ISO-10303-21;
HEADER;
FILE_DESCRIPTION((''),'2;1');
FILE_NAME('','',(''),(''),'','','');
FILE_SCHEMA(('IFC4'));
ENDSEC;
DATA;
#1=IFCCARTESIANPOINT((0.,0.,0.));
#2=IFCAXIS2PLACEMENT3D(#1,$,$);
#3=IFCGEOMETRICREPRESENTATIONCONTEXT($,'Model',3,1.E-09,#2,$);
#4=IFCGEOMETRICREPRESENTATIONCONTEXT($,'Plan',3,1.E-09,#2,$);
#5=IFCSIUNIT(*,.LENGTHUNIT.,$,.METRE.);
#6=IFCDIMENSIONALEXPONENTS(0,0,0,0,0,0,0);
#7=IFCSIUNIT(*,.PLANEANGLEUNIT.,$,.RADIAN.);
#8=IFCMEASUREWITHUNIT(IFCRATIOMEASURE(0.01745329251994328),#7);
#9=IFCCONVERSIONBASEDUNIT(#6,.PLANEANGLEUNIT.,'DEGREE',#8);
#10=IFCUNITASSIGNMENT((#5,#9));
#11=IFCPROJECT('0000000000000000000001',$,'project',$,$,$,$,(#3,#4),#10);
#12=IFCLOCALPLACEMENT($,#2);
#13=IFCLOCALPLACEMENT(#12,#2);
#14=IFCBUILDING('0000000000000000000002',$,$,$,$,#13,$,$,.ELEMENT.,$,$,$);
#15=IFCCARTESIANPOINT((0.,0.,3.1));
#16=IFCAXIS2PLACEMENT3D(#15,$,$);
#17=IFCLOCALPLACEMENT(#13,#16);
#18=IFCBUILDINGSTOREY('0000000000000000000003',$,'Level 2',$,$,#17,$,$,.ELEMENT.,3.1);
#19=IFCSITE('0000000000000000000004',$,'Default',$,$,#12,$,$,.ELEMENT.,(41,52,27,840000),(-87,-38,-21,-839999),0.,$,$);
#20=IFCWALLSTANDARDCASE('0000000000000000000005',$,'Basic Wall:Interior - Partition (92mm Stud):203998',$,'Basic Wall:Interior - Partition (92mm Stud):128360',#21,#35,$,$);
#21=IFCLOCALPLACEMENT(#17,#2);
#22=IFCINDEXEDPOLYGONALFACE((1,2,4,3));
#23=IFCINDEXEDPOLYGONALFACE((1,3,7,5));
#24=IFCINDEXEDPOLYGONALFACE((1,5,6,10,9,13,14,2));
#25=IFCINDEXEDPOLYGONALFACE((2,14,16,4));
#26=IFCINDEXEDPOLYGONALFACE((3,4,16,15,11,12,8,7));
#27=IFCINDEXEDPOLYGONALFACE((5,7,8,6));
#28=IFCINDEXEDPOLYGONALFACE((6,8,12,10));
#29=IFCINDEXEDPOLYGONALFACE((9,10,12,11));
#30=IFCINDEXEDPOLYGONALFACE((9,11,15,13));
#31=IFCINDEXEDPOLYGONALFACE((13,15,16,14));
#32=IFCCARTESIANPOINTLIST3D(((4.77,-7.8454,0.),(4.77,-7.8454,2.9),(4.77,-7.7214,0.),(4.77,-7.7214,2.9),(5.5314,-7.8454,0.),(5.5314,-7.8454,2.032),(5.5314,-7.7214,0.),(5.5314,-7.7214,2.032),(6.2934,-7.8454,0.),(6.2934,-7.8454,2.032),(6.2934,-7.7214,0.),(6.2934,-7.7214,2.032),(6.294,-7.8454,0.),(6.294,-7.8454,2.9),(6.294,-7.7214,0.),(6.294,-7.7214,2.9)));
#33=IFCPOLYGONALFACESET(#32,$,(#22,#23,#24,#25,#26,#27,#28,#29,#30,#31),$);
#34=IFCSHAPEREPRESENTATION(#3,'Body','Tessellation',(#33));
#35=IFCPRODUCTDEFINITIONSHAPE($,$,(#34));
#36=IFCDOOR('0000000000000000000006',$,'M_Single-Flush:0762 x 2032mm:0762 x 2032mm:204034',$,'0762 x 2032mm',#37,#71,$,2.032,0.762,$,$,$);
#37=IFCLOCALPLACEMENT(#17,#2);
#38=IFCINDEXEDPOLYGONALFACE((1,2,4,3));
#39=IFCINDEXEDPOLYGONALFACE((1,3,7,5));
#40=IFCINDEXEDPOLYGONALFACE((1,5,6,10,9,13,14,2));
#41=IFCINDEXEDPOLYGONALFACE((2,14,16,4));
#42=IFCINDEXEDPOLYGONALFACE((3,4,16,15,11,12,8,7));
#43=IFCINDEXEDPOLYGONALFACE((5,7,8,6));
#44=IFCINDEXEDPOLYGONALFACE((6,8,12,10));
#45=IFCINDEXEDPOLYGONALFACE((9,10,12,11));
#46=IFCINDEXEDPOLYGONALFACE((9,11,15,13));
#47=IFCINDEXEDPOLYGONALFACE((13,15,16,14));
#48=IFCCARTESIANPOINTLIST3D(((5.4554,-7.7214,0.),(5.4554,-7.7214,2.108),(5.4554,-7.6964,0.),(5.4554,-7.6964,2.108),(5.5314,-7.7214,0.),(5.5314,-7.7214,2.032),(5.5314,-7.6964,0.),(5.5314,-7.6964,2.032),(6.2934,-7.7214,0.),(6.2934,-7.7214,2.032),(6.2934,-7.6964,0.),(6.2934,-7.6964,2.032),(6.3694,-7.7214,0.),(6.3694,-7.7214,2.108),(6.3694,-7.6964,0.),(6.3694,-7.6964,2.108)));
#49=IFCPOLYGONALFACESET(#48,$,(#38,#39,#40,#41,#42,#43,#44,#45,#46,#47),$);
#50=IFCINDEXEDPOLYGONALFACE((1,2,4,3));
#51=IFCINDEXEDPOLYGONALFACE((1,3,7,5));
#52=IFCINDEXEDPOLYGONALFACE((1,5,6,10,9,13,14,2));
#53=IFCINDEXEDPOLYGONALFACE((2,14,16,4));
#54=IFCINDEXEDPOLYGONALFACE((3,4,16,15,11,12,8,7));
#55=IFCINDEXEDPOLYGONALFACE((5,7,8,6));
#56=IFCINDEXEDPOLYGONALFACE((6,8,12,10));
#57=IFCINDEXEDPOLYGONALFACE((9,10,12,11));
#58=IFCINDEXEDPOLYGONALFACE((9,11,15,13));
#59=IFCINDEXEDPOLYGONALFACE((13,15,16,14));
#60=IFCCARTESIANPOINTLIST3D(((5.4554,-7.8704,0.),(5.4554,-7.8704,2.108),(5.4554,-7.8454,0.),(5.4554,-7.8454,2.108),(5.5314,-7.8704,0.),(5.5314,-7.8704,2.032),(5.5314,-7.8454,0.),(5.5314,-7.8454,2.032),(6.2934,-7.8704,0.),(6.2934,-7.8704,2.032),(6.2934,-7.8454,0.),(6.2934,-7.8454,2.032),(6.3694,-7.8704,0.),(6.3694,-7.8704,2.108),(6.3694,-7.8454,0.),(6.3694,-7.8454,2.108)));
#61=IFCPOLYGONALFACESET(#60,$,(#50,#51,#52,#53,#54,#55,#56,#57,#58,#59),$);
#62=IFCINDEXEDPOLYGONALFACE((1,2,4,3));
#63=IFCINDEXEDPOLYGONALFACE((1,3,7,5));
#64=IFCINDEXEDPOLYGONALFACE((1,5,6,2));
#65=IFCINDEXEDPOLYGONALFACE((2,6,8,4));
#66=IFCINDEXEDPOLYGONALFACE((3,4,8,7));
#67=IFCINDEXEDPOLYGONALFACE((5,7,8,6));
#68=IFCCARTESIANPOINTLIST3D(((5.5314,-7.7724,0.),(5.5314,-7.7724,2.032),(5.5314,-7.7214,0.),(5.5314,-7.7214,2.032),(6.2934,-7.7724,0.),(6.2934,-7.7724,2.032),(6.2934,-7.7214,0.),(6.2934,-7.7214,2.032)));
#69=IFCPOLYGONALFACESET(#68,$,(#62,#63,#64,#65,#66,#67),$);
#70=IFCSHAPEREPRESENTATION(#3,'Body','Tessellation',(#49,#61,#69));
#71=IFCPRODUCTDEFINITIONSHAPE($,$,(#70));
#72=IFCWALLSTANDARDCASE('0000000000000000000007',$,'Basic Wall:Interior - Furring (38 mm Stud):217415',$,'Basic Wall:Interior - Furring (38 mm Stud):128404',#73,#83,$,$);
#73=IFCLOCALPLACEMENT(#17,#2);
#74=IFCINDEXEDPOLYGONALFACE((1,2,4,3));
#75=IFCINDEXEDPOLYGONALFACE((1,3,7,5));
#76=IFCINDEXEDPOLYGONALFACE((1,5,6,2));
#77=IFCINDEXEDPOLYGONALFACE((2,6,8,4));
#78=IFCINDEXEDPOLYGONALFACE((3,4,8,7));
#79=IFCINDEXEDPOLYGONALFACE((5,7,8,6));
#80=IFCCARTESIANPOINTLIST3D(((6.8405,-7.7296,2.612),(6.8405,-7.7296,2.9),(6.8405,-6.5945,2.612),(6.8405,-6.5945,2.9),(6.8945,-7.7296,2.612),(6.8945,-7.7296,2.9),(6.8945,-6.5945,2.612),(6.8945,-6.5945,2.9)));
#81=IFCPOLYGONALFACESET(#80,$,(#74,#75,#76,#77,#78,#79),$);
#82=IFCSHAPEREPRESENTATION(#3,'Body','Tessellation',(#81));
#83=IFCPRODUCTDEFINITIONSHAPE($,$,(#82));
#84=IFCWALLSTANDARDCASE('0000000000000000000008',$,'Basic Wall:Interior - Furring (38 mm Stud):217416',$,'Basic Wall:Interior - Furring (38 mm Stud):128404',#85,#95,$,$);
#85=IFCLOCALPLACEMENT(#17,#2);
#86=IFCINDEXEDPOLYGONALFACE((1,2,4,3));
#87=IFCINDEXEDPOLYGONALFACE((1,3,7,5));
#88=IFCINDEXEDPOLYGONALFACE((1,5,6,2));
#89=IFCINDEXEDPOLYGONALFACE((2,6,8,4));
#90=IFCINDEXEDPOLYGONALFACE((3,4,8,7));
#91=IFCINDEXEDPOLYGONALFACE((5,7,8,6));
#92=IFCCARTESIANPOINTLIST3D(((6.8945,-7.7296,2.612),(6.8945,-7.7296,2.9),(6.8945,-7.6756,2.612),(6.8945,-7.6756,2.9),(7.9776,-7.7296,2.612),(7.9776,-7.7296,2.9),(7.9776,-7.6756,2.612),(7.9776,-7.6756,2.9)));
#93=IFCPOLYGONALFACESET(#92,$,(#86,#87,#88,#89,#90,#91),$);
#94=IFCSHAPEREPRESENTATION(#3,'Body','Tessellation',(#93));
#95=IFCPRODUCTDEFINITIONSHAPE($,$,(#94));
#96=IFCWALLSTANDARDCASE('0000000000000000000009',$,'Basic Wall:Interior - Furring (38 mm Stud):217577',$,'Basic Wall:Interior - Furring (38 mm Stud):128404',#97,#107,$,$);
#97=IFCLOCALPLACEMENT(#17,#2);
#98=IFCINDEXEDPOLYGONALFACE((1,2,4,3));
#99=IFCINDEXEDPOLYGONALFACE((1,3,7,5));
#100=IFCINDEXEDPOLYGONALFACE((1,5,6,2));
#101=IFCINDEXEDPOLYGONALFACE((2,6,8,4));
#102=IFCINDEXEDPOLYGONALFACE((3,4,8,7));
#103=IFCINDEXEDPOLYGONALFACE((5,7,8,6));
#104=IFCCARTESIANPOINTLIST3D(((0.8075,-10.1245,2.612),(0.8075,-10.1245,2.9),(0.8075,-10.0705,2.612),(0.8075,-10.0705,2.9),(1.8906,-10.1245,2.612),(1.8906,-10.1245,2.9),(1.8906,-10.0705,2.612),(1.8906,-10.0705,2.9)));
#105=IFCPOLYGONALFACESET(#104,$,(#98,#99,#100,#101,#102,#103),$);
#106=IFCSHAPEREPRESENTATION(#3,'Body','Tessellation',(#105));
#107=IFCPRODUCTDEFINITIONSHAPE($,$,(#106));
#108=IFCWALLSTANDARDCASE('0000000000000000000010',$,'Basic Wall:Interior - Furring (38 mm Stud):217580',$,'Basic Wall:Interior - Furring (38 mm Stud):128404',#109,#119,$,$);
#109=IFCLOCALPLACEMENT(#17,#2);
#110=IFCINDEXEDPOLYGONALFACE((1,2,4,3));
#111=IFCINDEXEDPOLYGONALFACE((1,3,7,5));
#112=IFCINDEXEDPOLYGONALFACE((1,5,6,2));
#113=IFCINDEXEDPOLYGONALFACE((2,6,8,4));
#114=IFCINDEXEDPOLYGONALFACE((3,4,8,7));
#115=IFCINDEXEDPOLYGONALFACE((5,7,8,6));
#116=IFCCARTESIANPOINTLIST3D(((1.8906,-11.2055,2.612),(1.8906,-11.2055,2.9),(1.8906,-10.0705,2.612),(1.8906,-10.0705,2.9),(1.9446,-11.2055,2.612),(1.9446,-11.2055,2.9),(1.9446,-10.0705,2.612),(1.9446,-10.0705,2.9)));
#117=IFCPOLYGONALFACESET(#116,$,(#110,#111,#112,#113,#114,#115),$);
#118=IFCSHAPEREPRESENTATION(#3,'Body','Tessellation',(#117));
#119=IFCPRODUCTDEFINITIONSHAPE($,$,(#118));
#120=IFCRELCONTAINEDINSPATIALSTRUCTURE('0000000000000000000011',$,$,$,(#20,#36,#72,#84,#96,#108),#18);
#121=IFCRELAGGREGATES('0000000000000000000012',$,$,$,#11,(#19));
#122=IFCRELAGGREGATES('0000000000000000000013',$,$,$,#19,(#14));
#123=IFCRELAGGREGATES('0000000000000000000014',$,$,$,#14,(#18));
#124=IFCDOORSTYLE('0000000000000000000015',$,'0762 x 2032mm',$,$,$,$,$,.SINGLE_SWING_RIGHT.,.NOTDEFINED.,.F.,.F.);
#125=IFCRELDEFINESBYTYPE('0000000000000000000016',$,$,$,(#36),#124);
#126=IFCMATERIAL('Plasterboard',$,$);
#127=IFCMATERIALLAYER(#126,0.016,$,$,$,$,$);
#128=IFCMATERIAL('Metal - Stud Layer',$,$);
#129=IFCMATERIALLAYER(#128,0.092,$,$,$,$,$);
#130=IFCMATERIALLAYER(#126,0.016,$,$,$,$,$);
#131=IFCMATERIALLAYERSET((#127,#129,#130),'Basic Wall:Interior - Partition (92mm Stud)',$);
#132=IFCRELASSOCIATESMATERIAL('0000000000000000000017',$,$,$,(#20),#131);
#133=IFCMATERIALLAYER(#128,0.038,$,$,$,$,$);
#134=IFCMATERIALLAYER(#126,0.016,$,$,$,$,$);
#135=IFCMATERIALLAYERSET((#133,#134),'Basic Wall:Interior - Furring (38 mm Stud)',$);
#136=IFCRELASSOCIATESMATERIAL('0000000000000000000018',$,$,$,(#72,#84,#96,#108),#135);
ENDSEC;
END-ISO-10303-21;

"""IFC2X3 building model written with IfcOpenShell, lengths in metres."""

from ifc_helpers import new_model, entity, si_unit, converted_unit, frame, frame_2d, origin, origin_2d_with_axis, place, context, project, spatial, polyline, rectangle, outline, extrude, source, transform, mapped, material, layer, layer_set, layer_usage, type_object, type_shapes, element, fill, save


model = new_model("IFC2X3")

# Units and contexts
model_context = context("Model", 3, precision=1e-09, world=origin())
plan_context = context("Plan", 3, precision=1e-09, world=origin())
ifc_project = project(units=[si_unit("LENGTHUNIT", "METRE"), converted_unit("PLANEANGLEUNIT", "DEGREE", entity("IfcRatioMeasure", 0.01745329251994328), si_unit("PLANEANGLEUNIT", "RADIAN"), dimensions=[0, 0, 0, 0, 0, 0, 0])], contexts=[model_context, plan_context])

# Site, building, storey
site_placement = place(None, origin())
site = spatial("IfcSite", under=ifc_project, at=site_placement, Name="Default", CompositionType="ELEMENT", RefLatitude=(41, 52, 27, 840000), RefLongitude=(-87, -38, -21, -839999), RefElevation=0.0)
building_placement = place(site_placement, origin())
building = spatial("IfcBuilding", under=site, at=building_placement, CompositionType="ELEMENT")
storey_placement = place(building_placement, frame((0.0, 0.0, 3.1)))
storey = spatial("IfcBuildingStorey", under=building, at=storey_placement, Name="Level 2", CompositionType="ELEMENT", Elevation=3.1)

# Shared definitions
ifc_material_1 = material(Name="Plasterboard")
ifc_material_2 = material(Name="Metal - Stud Layer")
ifc_layer_1 = layer(ifc_material_1, 0.016)
ifc_layer_2 = layer(ifc_material_2, 0.092)
ifc_layer_3 = layer(ifc_material_1, 0.016)
ifc_layer_set_1 = layer_set([ifc_layer_1, ifc_layer_2, ifc_layer_3], Name="Basic Wall:Interior - Partition (92mm Stud)")

# Wall, opening, door
door_style = type_object("IfcDoorStyle", Name="0762 x 2032mm", ConstructionType="NOTDEFINED", OperationType="SINGLE_SWING_RIGHT", ParameterTakesPrecedence=False, Sizeable=False)
shared_shape = source(origin(), model_context, "Body", "SweptSolid", [
    extrude(outline(polyline([(-0.457, -1.073), (0.457, -1.073), (0.457, 1.035), (0.381, 1.035), (0.381, -0.997), (-0.381, -0.997), (-0.381, 1.035), (-0.457, 1.035), (-0.457, -1.073)])), frame((0.381, 0.124, 1.035), z_axis=(0.0, 1.0, 0.0), x_axis=(1.0, 0.0, 0.0)), (0.0, 0.0, 1.0), 0.025),
    extrude(outline(polyline([(-1.073, -0.457), (1.035, -0.457), (1.035, -0.381), (-0.997, -0.381), (-0.997, 0.381), (1.035, 0.381), (1.035, 0.457), (-1.073, 0.457), (-1.073, -0.457)])), frame((0.381, -0.025, 1.035), z_axis=(0.0, 1.0, 0.0), x_axis=(0.0, 0.0, -1.0)), (0.0, 0.0, 1.0), 0.025),
    extrude(rectangle(XDim=0.051, YDim=0.762, at=origin_2d_with_axis()), frame((0.381, 0.0985, 0.0), z_axis=(0.0, 0.0, 1.0), x_axis=(0.0, 1.0, 0.0)), (0.0, 0.0, 1.0), 2.032),
])
type_shapes(door_style, [shared_shape])
ifc_layer_usage_1 = layer_usage(ifc_layer_set_1, "AXIS2", "POSITIVE", -0.062)
wall_1_placement = place(storey_placement, frame((4.77, -7.7834, 0.0)))
wall_1 = element("IfcWallStandardCase", 1, at=wall_1_placement, inside=storey, material=ifc_layer_usage_1, Name="Basic Wall:Interior - Partition (92mm Stud):203998", ObjectType="Basic Wall:Interior - Partition (92mm Stud):128360", context=model_context, shape_type="SweptSolid", body=[
    extrude(rectangle(XDim=1.524, YDim=0.124, at=frame_2d((0.762, 0.0), x_axis=(-1.0, 0.0))), origin(), (0.0, 0.0, 1.0), 2.9),
])
opening_1_placement = place(wall_1_placement, frame((0.7614, -0.062, 0.0)))
opening_1 = element("IfcOpeningElement", 2, at=opening_1_placement, cuts=wall_1, ObjectType="Opening", context=model_context, shape_type="SweptSolid", body=[
    extrude(rectangle(XDim=0.762, YDim=2.032, at=frame_2d((1.016, 0.381), x_axis=(0.0, 1.0))), frame((0.0, 0.0, 0.0), z_axis=(0.0, 1.0, 0.0), x_axis=(0.0, 0.0, 1.0)), (0.0, 0.0, 1.0), 0.124),
])
door_1_placement = place(opening_1_placement, origin())
door_1 = element("IfcDoor", 3, at=door_1_placement, inside=storey, type_object=door_style, Name="M_Single-Flush:0762 x 2032mm:0762 x 2032mm:204034", ObjectType="0762 x 2032mm", OverallHeight=2.032, OverallWidth=0.762, context=model_context, shape_type="MappedRepresentation", body=[
    mapped(shared_shape, transform((0.0, 0.0, 0.0), scale=1.0)),
])
fill(opening_1, door_1)

# Walls
ifc_layer_4 = layer(ifc_material_2, 0.038)
ifc_layer_5 = layer(ifc_material_1, 0.016)
ifc_layer_set_2 = layer_set([ifc_layer_4, ifc_layer_5], Name="Basic Wall:Interior - Furring (38 mm Stud)")
ifc_layer_usage_2 = layer_usage(ifc_layer_set_2, "AXIS2", "NEGATIVE", 0.027)
wall_2_placement = place(storey_placement, frame((6.8675, -7.7296, 2.612), z_axis=(0.0, 0.0, 1.0), x_axis=(0.0, 1.0, 0.0)))
element("IfcWallStandardCase", 4, at=wall_2_placement, inside=storey, material=ifc_layer_usage_2, Name="Basic Wall:Interior - Furring (38 mm Stud):217415", ObjectType="Basic Wall:Interior - Furring (38 mm Stud):128404", context=model_context, shape_type="SweptSolid", body=[
    extrude(rectangle(XDim=1.1351, YDim=0.054, at=frame_2d((0.5675, 0.0), x_axis=(-1.0, 0.0))), origin(), (0.0, 0.0, 1.0), 0.288),
])
ifc_layer_usage_3 = layer_usage(ifc_layer_set_2, "AXIS2", "NEGATIVE", 0.027)
wall_3_placement = place(storey_placement, frame((7.9776, -7.7026, 2.612), z_axis=(0.0, 0.0, 1.0), x_axis=(-1.0, 0.0, 0.0)))
element("IfcWallStandardCase", 5, at=wall_3_placement, inside=storey, material=ifc_layer_usage_3, Name="Basic Wall:Interior - Furring (38 mm Stud):217416", ObjectType="Basic Wall:Interior - Furring (38 mm Stud):128404", context=model_context, shape_type="SweptSolid", body=[
    extrude(rectangle(XDim=1.0831, YDim=0.054, at=frame_2d((0.5416, 0.0), x_axis=(-1.0, 0.0))), origin(), (0.0, 0.0, 1.0), 0.288),
])
ifc_layer_usage_4 = layer_usage(ifc_layer_set_2, "AXIS2", "NEGATIVE", 0.027)
wall_4_placement = place(storey_placement, frame((0.8075, -10.0975, 2.612)))
element("IfcWallStandardCase", 6, at=wall_4_placement, inside=storey, material=ifc_layer_usage_4, Name="Basic Wall:Interior - Furring (38 mm Stud):217577", ObjectType="Basic Wall:Interior - Furring (38 mm Stud):128404", context=model_context, shape_type="SweptSolid", body=[
    extrude(rectangle(XDim=1.0831, YDim=0.054, at=frame_2d((0.5415, 0.0), x_axis=(-1.0, 0.0))), origin(), (0.0, 0.0, 1.0), 0.288),
])
ifc_layer_usage_5 = layer_usage(ifc_layer_set_2, "AXIS2", "NEGATIVE", 0.027)
wall_5_placement = place(storey_placement, frame((1.9176, -10.0705, 2.612), z_axis=(0.0, 0.0, 1.0), x_axis=(0.0, -1.0, 0.0)))
element("IfcWallStandardCase", 7, at=wall_5_placement, inside=storey, material=ifc_layer_usage_5, Name="Basic Wall:Interior - Furring (38 mm Stud):217580", ObjectType="Basic Wall:Interior - Furring (38 mm Stud):128404", context=model_context, shape_type="SweptSolid", body=[
    extrude(rectangle(XDim=1.1351, YDim=0.054, at=frame_2d((0.5675, 0.0), x_axis=(-1.0, 0.0))), origin(), (0.0, 0.0, 1.0), 0.288),
])

save(model, "model.ifc")
